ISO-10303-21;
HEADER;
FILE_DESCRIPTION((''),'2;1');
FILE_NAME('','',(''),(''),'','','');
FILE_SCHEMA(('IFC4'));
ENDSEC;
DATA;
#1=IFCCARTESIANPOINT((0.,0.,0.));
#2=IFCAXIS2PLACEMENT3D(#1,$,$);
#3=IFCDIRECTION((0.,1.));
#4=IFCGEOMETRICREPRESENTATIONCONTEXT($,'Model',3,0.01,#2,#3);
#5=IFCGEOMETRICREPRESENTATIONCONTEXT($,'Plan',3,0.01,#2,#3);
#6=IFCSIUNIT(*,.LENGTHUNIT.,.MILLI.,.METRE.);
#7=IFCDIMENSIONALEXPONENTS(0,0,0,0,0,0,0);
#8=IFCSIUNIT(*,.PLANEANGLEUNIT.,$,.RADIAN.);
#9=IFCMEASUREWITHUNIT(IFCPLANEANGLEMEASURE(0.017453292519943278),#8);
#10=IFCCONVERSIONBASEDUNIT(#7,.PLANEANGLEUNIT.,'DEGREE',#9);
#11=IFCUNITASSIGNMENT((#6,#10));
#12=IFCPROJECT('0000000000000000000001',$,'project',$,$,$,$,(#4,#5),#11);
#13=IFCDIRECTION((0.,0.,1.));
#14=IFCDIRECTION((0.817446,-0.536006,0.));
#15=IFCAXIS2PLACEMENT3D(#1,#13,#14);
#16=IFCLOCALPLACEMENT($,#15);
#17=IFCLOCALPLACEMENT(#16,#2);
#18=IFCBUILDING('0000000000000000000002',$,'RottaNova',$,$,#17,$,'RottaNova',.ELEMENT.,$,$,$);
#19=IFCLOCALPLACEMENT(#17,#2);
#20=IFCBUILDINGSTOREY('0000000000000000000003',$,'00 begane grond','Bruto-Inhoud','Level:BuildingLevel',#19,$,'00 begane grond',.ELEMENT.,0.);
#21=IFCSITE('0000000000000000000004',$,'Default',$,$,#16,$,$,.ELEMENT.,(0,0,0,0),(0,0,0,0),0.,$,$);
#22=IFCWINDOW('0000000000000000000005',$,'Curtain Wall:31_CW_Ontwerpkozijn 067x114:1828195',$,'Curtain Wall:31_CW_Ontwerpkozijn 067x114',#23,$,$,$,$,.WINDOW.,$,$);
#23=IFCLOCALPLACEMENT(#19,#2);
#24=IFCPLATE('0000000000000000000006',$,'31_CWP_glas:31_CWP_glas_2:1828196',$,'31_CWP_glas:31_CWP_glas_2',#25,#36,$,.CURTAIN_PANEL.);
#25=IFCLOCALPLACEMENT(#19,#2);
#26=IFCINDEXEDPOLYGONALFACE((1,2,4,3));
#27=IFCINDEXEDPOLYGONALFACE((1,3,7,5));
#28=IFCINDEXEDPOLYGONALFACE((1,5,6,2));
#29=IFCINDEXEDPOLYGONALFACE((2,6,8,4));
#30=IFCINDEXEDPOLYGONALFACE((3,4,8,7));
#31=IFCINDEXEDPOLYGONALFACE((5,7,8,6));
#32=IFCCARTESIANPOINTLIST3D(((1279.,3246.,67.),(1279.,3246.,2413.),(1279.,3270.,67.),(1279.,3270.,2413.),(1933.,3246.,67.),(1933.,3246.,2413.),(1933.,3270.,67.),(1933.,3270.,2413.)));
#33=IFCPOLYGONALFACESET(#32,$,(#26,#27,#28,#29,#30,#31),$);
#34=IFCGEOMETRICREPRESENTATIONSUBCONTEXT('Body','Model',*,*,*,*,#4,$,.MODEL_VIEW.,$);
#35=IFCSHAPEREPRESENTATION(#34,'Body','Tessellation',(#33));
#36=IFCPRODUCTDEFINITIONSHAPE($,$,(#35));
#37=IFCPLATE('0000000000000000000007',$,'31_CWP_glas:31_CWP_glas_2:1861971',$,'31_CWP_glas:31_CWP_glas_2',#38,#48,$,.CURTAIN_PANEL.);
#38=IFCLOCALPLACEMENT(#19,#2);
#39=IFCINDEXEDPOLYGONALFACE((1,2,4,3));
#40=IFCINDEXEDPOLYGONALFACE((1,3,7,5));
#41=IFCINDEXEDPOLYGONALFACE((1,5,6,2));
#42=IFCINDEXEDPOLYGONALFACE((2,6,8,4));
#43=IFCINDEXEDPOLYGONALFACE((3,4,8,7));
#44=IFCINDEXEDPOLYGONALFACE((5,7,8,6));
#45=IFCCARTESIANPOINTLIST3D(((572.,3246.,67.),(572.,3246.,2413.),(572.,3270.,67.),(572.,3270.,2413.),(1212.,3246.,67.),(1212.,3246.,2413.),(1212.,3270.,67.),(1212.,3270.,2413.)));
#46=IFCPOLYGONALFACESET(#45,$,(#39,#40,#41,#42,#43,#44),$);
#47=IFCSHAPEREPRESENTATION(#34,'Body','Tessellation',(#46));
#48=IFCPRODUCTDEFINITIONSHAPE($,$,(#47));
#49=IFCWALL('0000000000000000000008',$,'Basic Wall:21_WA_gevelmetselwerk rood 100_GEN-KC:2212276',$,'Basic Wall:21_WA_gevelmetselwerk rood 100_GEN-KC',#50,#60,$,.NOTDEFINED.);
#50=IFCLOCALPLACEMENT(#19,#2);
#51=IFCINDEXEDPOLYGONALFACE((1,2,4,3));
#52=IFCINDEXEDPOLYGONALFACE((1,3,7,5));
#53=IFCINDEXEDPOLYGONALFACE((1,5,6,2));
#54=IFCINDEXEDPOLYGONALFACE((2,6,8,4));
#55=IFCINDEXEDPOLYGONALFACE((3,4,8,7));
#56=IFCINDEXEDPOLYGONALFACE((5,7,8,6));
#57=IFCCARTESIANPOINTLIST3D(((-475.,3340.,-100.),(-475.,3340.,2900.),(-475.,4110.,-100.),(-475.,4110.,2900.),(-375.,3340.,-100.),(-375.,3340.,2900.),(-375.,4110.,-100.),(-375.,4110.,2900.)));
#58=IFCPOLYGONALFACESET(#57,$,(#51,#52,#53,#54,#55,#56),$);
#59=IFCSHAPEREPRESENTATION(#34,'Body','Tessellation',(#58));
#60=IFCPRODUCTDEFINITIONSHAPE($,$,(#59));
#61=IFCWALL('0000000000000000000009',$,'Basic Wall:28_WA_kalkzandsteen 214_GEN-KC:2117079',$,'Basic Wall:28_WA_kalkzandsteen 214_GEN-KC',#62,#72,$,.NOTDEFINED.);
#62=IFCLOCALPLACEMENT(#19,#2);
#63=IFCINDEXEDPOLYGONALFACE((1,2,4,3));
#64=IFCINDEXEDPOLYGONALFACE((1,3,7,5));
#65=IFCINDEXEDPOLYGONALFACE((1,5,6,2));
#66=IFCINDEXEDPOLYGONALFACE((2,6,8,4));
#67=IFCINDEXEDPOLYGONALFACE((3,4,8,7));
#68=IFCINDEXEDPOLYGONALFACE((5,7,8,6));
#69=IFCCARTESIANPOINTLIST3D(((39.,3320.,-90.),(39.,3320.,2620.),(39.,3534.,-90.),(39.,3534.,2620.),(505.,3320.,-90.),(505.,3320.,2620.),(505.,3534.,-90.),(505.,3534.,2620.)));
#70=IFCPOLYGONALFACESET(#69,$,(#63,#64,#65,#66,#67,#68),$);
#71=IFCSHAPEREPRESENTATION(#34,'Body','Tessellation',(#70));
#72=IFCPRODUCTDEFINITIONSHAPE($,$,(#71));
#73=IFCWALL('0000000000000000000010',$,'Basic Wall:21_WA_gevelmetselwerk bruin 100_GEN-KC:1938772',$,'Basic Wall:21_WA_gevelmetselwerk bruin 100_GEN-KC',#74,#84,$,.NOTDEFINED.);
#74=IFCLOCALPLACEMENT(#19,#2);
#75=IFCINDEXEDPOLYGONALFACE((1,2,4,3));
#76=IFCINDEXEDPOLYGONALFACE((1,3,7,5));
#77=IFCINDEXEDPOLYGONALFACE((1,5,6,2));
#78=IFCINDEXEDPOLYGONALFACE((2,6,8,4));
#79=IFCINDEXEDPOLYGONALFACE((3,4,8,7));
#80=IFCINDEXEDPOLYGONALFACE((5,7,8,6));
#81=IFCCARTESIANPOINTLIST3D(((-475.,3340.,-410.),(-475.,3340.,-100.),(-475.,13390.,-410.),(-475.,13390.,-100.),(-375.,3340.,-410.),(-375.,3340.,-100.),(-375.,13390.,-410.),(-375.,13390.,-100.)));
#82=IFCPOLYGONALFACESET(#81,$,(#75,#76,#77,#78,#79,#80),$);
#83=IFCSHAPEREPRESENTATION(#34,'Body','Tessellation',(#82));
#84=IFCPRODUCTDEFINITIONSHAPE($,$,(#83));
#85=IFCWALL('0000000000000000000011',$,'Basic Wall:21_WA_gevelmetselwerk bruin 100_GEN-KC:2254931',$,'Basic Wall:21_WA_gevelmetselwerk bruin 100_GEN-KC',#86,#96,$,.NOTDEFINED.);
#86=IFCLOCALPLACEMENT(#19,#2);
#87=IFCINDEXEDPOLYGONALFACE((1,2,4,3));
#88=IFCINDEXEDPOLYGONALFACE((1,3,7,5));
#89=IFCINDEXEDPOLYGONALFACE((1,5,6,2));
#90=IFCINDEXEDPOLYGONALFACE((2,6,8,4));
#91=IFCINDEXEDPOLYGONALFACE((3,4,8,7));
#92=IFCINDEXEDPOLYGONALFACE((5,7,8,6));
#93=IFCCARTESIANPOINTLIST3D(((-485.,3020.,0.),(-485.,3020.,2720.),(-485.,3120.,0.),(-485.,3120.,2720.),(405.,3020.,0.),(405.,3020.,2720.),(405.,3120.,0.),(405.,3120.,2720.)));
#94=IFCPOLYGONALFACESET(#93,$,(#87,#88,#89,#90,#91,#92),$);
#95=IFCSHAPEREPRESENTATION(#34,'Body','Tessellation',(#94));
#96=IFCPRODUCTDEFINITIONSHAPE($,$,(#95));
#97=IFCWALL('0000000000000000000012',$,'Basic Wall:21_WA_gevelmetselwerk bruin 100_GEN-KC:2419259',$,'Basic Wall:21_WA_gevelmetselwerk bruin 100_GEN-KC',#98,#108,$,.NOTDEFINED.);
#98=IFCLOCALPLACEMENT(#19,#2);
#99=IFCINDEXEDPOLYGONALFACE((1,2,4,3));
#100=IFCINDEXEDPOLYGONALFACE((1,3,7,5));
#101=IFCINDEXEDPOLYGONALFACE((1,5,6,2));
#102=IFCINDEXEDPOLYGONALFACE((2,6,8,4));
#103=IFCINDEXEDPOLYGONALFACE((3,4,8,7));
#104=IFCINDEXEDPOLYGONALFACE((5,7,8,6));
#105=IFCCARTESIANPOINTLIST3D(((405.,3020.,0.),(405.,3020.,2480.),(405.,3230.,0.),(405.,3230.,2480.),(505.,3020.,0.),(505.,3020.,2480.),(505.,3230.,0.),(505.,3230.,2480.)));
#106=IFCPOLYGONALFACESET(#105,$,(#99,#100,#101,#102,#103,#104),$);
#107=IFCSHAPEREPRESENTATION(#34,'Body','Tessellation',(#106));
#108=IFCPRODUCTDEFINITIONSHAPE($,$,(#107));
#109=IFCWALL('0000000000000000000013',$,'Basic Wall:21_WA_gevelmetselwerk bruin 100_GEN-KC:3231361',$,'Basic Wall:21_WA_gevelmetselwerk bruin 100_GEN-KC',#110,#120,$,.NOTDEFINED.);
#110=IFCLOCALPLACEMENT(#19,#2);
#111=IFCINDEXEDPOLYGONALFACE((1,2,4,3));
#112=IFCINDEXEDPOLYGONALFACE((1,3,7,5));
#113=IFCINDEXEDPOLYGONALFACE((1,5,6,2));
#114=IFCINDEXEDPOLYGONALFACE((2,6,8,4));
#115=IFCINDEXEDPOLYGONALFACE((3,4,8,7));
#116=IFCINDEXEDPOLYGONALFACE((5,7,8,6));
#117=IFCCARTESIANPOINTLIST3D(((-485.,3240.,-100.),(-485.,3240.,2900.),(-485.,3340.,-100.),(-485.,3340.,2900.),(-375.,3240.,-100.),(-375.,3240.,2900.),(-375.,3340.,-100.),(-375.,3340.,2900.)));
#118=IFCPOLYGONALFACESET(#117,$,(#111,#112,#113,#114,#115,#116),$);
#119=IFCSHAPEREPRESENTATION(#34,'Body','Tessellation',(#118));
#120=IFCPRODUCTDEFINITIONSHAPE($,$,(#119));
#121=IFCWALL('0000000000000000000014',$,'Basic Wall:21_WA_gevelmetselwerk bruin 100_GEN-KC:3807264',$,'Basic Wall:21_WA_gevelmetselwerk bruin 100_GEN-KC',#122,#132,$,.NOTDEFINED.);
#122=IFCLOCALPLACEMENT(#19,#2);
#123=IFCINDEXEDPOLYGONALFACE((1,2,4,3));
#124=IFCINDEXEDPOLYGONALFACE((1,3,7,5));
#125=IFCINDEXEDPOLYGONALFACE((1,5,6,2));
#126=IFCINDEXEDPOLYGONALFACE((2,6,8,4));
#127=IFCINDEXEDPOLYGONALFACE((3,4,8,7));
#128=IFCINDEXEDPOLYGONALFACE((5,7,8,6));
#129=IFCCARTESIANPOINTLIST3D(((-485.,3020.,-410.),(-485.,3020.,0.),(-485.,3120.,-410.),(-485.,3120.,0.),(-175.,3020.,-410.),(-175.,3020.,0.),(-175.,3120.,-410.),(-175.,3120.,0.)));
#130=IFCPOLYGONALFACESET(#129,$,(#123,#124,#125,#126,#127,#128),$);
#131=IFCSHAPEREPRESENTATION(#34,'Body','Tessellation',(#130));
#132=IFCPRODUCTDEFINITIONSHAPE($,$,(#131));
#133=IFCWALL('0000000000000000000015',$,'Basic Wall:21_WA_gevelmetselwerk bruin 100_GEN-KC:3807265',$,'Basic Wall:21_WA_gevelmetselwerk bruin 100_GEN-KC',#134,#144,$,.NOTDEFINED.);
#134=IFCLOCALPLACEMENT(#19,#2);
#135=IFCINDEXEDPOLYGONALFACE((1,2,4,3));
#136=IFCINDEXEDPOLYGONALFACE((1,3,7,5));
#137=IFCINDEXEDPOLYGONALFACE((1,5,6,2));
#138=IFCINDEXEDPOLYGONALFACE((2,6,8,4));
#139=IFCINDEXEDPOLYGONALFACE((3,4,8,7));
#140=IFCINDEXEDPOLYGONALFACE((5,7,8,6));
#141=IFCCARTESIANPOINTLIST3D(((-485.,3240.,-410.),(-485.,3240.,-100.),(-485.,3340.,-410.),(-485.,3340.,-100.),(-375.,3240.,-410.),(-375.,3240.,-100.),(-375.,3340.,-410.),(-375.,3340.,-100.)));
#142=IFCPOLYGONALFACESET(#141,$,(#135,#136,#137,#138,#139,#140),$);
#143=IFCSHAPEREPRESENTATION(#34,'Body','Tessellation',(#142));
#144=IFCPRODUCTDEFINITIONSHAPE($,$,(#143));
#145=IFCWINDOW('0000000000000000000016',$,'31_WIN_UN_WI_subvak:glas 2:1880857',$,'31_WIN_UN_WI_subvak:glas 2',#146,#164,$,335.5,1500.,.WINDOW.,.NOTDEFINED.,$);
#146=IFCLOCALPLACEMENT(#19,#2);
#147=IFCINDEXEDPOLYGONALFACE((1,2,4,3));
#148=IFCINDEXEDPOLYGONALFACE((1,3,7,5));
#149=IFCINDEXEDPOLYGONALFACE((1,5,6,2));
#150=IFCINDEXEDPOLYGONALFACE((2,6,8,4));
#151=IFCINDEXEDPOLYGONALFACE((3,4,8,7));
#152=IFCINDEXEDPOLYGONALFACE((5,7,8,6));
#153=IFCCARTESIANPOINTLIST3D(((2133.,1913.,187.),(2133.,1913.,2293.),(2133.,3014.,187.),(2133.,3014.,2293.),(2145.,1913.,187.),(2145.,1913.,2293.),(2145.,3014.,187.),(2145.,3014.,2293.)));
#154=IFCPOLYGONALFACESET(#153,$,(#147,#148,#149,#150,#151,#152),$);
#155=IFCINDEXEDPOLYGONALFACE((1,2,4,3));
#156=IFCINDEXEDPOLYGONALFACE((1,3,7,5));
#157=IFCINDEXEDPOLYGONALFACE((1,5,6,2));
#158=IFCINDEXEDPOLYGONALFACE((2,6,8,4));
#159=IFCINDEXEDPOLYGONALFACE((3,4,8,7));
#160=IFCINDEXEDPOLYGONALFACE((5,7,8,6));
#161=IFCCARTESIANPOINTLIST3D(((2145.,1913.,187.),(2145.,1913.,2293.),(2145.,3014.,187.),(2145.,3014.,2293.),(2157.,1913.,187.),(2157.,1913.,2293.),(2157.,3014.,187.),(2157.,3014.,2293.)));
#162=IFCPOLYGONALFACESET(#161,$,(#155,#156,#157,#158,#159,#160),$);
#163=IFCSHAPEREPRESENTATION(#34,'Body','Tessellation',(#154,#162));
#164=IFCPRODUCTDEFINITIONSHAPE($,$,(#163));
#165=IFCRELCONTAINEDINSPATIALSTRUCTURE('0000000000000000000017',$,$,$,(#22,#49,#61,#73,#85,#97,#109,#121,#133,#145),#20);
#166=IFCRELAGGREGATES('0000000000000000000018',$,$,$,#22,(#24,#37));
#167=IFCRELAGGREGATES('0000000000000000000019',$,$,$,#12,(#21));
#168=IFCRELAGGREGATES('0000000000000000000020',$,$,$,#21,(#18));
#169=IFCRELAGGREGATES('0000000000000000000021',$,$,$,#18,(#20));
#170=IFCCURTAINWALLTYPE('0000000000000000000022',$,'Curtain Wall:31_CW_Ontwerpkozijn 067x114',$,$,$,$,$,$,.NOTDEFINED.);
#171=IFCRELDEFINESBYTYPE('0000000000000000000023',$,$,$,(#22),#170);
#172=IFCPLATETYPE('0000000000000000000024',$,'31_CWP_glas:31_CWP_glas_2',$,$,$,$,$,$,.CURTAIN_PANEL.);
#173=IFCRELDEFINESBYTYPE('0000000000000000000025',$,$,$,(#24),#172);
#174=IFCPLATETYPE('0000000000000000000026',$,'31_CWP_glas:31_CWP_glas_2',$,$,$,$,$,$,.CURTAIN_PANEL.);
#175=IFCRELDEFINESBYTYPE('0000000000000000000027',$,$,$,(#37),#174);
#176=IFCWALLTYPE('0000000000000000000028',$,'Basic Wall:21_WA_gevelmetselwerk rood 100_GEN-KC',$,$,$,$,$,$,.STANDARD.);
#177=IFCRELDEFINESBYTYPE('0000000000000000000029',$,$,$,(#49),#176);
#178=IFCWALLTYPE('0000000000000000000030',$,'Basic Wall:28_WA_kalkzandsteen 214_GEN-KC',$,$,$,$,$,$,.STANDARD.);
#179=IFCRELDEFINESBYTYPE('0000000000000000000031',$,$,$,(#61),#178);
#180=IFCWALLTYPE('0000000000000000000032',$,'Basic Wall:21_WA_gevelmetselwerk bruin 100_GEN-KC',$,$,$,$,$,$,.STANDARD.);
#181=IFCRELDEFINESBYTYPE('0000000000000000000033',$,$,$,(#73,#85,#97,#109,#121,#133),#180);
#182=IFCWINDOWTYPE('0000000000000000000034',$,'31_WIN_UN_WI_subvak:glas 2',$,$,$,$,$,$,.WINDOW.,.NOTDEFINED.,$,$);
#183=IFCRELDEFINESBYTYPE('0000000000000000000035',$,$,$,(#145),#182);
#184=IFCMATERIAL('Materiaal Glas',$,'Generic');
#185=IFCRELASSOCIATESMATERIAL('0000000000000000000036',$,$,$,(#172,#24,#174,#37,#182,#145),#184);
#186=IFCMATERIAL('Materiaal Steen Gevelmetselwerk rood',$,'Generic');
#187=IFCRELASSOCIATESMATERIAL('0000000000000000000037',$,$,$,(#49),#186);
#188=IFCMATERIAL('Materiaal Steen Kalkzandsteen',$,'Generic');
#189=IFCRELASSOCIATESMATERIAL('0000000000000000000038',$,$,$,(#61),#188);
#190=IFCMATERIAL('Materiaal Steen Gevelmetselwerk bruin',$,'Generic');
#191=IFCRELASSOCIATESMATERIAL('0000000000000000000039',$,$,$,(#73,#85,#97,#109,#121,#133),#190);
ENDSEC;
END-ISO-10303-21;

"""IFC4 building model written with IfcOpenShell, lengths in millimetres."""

from ifc_helpers import new_model, entity, si_unit, converted_unit, direction, frame, origin, place, context, subcontext, project, spatial, indexed_curve, outline, extrude, source, transform, mapped, material, type_object, type_shapes, element, aggregate, save


model = new_model("IFC4")

# Units and contexts
model_context = context("Model", 3, precision=0.01, world=origin(), true_north=direction((0.0, 1.0)))
plan_context = context("Plan", 3, precision=0.01, world=origin(), true_north=direction((0.0, 1.0)))
body_context = subcontext(model_context, "Body", "Model", "MODEL_VIEW")
ifc_project = project(units=[si_unit("LENGTHUNIT", "METRE", prefix="MILLI"), converted_unit("PLANEANGLEUNIT", "DEGREE", entity("IfcPlaneAngleMeasure", 0.017453292519943278), si_unit("PLANEANGLEUNIT", "RADIAN"), dimensions=[0, 0, 0, 0, 0, 0, 0])], contexts=[model_context, plan_context])

# Site, building, storey
site_placement = place(None, frame((0.0, 0.0, 0.0), z_axis=(0.0, 0.0, 1.0), x_axis=(0.817446, -0.536006, 0.0)))
site = spatial("IfcSite", under=ifc_project, at=site_placement, Name="Default", CompositionType="ELEMENT", RefLatitude=(0, 0, 0, 0), RefLongitude=(0, 0, 0, 0), RefElevation=0.0)
building_placement = place(site_placement, origin())
building = spatial("IfcBuilding", under=site, at=building_placement, Name="RottaNova", LongName="RottaNova", CompositionType="ELEMENT")
storey_placement = place(building_placement, origin())
storey = spatial("IfcBuildingStorey", under=building, at=storey_placement, Name="00 begane grond", Description="Bruto-Inhoud", ObjectType="Level:BuildingLevel", LongName="00 begane grond", CompositionType="ELEMENT", Elevation=0.0)

# Window
curtain_wall_type = type_object("IfcCurtainWallType", Name="Curtain Wall:31_CW_Ontwerpkozijn 067x114", PredefinedType="NOTDEFINED")
window_1_placement = place(storey_placement, origin())
window_1 = element("IfcWindow", 1, at=window_1_placement, inside=storey, type_object=curtain_wall_type, Name="Curtain Wall:31_CW_Ontwerpkozijn 067x114:1828195", ObjectType="Curtain Wall:31_CW_Ontwerpkozijn 067x114", PredefinedType="WINDOW")

# Plates
ifc_material_1 = material(Name="Materiaal Glas", Category="Generic")
plate_type_1 = type_object("IfcPlateType", Name="31_CWP_glas:31_CWP_glas_2", PredefinedType="CURTAIN_PANEL", material=ifc_material_1)
shared_shape_1 = source(origin(), body_context, "Body", "SweptSolid", [
    extrude(outline(indexed_curve([(-12.0, -327.0), (12.0, -327.0), (12.0, 327.0), (-12.0, 327.0), (-12.0, -327.0)], self_intersect=False)), frame((0.0, 57.0, 0.0), z_axis=(0.0, 0.0, 1.0), x_axis=(0.0, 1.0, 0.0)), (0.0, 0.0, 1.0), 2346.0),
])
type_shapes(plate_type_1, [shared_shape_1])
plate_1_placement = place(window_1_placement, frame((1606.0, 3315.0, 67.0), z_axis=(0.0, 0.0, 1.0), x_axis=(-1.0, 0.0, 0.0)))
plate_1 = element("IfcPlate", 2, at=plate_1_placement, type_object=plate_type_1, material=ifc_material_1, Name="31_CWP_glas:31_CWP_glas_2:1828196", ObjectType="31_CWP_glas:31_CWP_glas_2", PredefinedType="CURTAIN_PANEL", context=body_context, shape_type="MappedRepresentation", body=[
    mapped(shared_shape_1, transform((0.0, 0.0, 0.0), scale=1.0)),
])
plate_type_2 = type_object("IfcPlateType", Name="31_CWP_glas:31_CWP_glas_2", PredefinedType="CURTAIN_PANEL", material=ifc_material_1)
shared_shape_2 = source(origin(), body_context, "Body", "SweptSolid", [
    extrude(outline(indexed_curve([(-12.0, -320.0), (12.0, -320.0), (12.0, 320.0), (-12.0, 320.0), (-12.0, -320.0)], self_intersect=False)), frame((0.0, 57.0, 0.0), z_axis=(0.0, 0.0, 1.0), x_axis=(0.0, 1.0, 0.0)), (0.0, 0.0, 1.0), 2346.0),
])
type_shapes(plate_type_2, [shared_shape_2])
plate_2_placement = place(window_1_placement, frame((892.0, 3315.0, 67.0), z_axis=(0.0, 0.0, 1.0), x_axis=(-1.0, 0.0, 0.0)))
plate_2 = element("IfcPlate", 3, at=plate_2_placement, type_object=plate_type_2, material=ifc_material_1, Name="31_CWP_glas:31_CWP_glas_2:1861971", ObjectType="31_CWP_glas:31_CWP_glas_2", PredefinedType="CURTAIN_PANEL", context=body_context, shape_type="MappedRepresentation", body=[
    mapped(shared_shape_2, transform((0.0, 0.0, 0.0), scale=1.0)),
])
aggregate(window_1, [plate_1, plate_2])

# Walls
ifc_material_2 = material(Name="Materiaal Steen Gevelmetselwerk rood", Category="Generic")
wall_type_1 = type_object("IfcWallType", Name="Basic Wall:21_WA_gevelmetselwerk rood 100_GEN-KC", PredefinedType="STANDARD")
wall_1_placement = place(storey_placement, frame((-425.0, 3340.0, -100.0), z_axis=(0.0, 0.0, 1.0), x_axis=(0.0, 1.0, 0.0)))
element("IfcWall", 4, at=wall_1_placement, inside=storey, type_object=wall_type_1, material=ifc_material_2, Name="Basic Wall:21_WA_gevelmetselwerk rood 100_GEN-KC:2212276", ObjectType="Basic Wall:21_WA_gevelmetselwerk rood 100_GEN-KC", PredefinedType="NOTDEFINED", context=body_context, shape_type="SweptSolid", body=[
    extrude(outline(indexed_curve([(770.0, 50.0), (0.0, 50.0), (0.0, -50.0), (770.0, -50.0), (770.0, 50.0)], self_intersect=False)), origin(), (0.0, 0.0, 1.0), 3000.0),
])
ifc_material_3 = material(Name="Materiaal Steen Kalkzandsteen", Category="Generic")
wall_type_2 = type_object("IfcWallType", Name="Basic Wall:28_WA_kalkzandsteen 214_GEN-KC", PredefinedType="STANDARD")
wall_2_placement = place(storey_placement, frame((39.0, 3427.0, -90.0)))
element("IfcWall", 5, at=wall_2_placement, inside=storey, type_object=wall_type_2, material=ifc_material_3, Name="Basic Wall:28_WA_kalkzandsteen 214_GEN-KC:2117079", ObjectType="Basic Wall:28_WA_kalkzandsteen 214_GEN-KC", PredefinedType="NOTDEFINED", context=body_context, shape_type="SweptSolid", body=[
    extrude(outline(indexed_curve([(466.0, 107.0), (0.0, 107.0), (0.0, -107.0), (466.0, -107.0), (466.0, 107.0)], self_intersect=False)), origin(), (0.0, 0.0, 1.0), 2710.0),
])
ifc_material_4 = material(Name="Materiaal Steen Gevelmetselwerk bruin", Category="Generic")
wall_type_3 = type_object("IfcWallType", Name="Basic Wall:21_WA_gevelmetselwerk bruin 100_GEN-KC", PredefinedType="STANDARD")
wall_3_placement = place(storey_placement, frame((-425.0, 3340.0, -410.0), z_axis=(0.0, 0.0, 1.0), x_axis=(0.0, 1.0, 0.0)))
element("IfcWall", 6, at=wall_3_placement, inside=storey, type_object=wall_type_3, material=ifc_material_4, Name="Basic Wall:21_WA_gevelmetselwerk bruin 100_GEN-KC:1938772", ObjectType="Basic Wall:21_WA_gevelmetselwerk bruin 100_GEN-KC", PredefinedType="NOTDEFINED", context=body_context, shape_type="SweptSolid", body=[
    extrude(outline(indexed_curve([(10050.0, 50.0), (0.0, 50.0), (0.0, -50.0), (10050.0, -50.0), (10050.0, 50.0)], self_intersect=False)), origin(), (0.0, 0.0, 1.0), 310.0),
])
wall_4_placement = place(storey_placement, frame((405.0, 3070.0, 0.0), z_axis=(0.0, 0.0, 1.0), x_axis=(-1.0, 0.0, 0.0)))
element("IfcWall", 7, at=wall_4_placement, inside=storey, type_object=wall_type_3, material=ifc_material_4, Name="Basic Wall:21_WA_gevelmetselwerk bruin 100_GEN-KC:2254931", ObjectType="Basic Wall:21_WA_gevelmetselwerk bruin 100_GEN-KC", PredefinedType="NOTDEFINED", context=body_context, shape_type="SweptSolid", body=[
    extrude(outline(indexed_curve([(890.0, 50.0), (0.0, 50.0), (0.0, -50.0), (890.0, -50.0), (890.0, 50.0)], self_intersect=False)), origin(), (0.0, 0.0, 1.0), 2720.0),
])
wall_5_placement = place(storey_placement, frame((455.0, 3230.0, 0.0), z_axis=(0.0, 0.0, 1.0), x_axis=(0.0, -1.0, 0.0)))
element("IfcWall", 8, at=wall_5_placement, inside=storey, type_object=wall_type_3, material=ifc_material_4, Name="Basic Wall:21_WA_gevelmetselwerk bruin 100_GEN-KC:2419259", ObjectType="Basic Wall:21_WA_gevelmetselwerk bruin 100_GEN-KC", PredefinedType="NOTDEFINED", context=body_context, shape_type="SweptSolid", body=[
    extrude(outline(indexed_curve([(210.0, 50.0), (0.0, 50.0), (0.0, -50.0), (210.0, -50.0), (210.0, 50.0)], self_intersect=False)), origin(), (0.0, 0.0, 1.0), 2480.0),
])
wall_6_placement = place(storey_placement, frame((-485.0, 3290.0, -100.0)))
element("IfcWall", 9, at=wall_6_placement, inside=storey, type_object=wall_type_3, material=ifc_material_4, Name="Basic Wall:21_WA_gevelmetselwerk bruin 100_GEN-KC:3231361", ObjectType="Basic Wall:21_WA_gevelmetselwerk bruin 100_GEN-KC", PredefinedType="NOTDEFINED", context=body_context, shape_type="SweptSolid", body=[
    extrude(outline(indexed_curve([(110.0, 50.0), (0.0, 50.0), (0.0, -50.0), (110.0, -50.0), (110.0, 50.0)], self_intersect=False)), origin(), (0.0, 0.0, 1.0), 3000.0),
])
wall_7_placement = place(storey_placement, frame((-175.0, 3070.0, -410.0), z_axis=(0.0, 0.0, 1.0), x_axis=(-1.0, 0.0, 0.0)))
element("IfcWall", 10, at=wall_7_placement, inside=storey, type_object=wall_type_3, material=ifc_material_4, Name="Basic Wall:21_WA_gevelmetselwerk bruin 100_GEN-KC:3807264", ObjectType="Basic Wall:21_WA_gevelmetselwerk bruin 100_GEN-KC", PredefinedType="NOTDEFINED", context=body_context, shape_type="SweptSolid", body=[
    extrude(outline(indexed_curve([(310.0, 50.0), (0.0, 50.0), (0.0, -50.0), (310.0, -50.0), (310.0, 50.0)], self_intersect=False)), origin(), (0.0, 0.0, 1.0), 410.0),
])
wall_8_placement = place(storey_placement, frame((-485.0, 3290.0, -410.0)))
element("IfcWall", 11, at=wall_8_placement, inside=storey, type_object=wall_type_3, material=ifc_material_4, Name="Basic Wall:21_WA_gevelmetselwerk bruin 100_GEN-KC:3807265", ObjectType="Basic Wall:21_WA_gevelmetselwerk bruin 100_GEN-KC", PredefinedType="NOTDEFINED", context=body_context, shape_type="SweptSolid", body=[
    extrude(outline(indexed_curve([(110.0, 50.0), (0.0, 50.0), (0.0, -50.0), (110.0, -50.0), (110.0, 50.0)], self_intersect=False)), origin(), (0.0, 0.0, 1.0), 310.0),
])

# Window
window_type = type_object("IfcWindowType", Name="31_WIN_UN_WI_subvak:glas 2", PartitioningType="NOTDEFINED", PredefinedType="WINDOW", material=ifc_material_1)
shared_shape_3 = source(origin(), body_context, "Body", "SweptSolid", [
    extrude(outline(indexed_curve([(-6.0, -550.5), (6.0, -550.5), (6.0, 550.5), (-6.0, 550.5), (-6.0, -550.5)], self_intersect=False)), frame((0.0, 6.0, 0.0), z_axis=(0.0, 0.0, 1.0), x_axis=(0.0, -1.0, 0.0)), (0.0, 0.0, 1.0), 2106.0),
    extrude(outline(indexed_curve([(-6.0, -550.5), (6.0, -550.5), (6.0, 550.5), (-6.0, 550.5), (-6.0, -550.5)], self_intersect=False)), frame((0.0, -6.0, 0.0), z_axis=(0.0, 0.0, 1.0), x_axis=(0.0, -1.0, 0.0)), (0.0, 0.0, 1.0), 2106.0),
])
type_shapes(window_type, [shared_shape_3])
window_2_placement = place(storey_placement, frame((2145.0, 2463.5, 187.0), z_axis=(0.0, 0.0, 1.0), x_axis=(0.0, 1.0, 0.0)))
element("IfcWindow", 12, at=window_2_placement, inside=storey, type_object=window_type, material=ifc_material_1, Name="31_WIN_UN_WI_subvak:glas 2:1880857", ObjectType="31_WIN_UN_WI_subvak:glas 2", OverallHeight=335.5, OverallWidth=1500.0, PartitioningType="NOTDEFINED", PredefinedType="WINDOW", context=body_context, shape_type="MappedRepresentation", body=[
    mapped(shared_shape_3, transform((0.0, 0.0, 0.0), scale=1.0)),
])

save(model, "model.ifc")
